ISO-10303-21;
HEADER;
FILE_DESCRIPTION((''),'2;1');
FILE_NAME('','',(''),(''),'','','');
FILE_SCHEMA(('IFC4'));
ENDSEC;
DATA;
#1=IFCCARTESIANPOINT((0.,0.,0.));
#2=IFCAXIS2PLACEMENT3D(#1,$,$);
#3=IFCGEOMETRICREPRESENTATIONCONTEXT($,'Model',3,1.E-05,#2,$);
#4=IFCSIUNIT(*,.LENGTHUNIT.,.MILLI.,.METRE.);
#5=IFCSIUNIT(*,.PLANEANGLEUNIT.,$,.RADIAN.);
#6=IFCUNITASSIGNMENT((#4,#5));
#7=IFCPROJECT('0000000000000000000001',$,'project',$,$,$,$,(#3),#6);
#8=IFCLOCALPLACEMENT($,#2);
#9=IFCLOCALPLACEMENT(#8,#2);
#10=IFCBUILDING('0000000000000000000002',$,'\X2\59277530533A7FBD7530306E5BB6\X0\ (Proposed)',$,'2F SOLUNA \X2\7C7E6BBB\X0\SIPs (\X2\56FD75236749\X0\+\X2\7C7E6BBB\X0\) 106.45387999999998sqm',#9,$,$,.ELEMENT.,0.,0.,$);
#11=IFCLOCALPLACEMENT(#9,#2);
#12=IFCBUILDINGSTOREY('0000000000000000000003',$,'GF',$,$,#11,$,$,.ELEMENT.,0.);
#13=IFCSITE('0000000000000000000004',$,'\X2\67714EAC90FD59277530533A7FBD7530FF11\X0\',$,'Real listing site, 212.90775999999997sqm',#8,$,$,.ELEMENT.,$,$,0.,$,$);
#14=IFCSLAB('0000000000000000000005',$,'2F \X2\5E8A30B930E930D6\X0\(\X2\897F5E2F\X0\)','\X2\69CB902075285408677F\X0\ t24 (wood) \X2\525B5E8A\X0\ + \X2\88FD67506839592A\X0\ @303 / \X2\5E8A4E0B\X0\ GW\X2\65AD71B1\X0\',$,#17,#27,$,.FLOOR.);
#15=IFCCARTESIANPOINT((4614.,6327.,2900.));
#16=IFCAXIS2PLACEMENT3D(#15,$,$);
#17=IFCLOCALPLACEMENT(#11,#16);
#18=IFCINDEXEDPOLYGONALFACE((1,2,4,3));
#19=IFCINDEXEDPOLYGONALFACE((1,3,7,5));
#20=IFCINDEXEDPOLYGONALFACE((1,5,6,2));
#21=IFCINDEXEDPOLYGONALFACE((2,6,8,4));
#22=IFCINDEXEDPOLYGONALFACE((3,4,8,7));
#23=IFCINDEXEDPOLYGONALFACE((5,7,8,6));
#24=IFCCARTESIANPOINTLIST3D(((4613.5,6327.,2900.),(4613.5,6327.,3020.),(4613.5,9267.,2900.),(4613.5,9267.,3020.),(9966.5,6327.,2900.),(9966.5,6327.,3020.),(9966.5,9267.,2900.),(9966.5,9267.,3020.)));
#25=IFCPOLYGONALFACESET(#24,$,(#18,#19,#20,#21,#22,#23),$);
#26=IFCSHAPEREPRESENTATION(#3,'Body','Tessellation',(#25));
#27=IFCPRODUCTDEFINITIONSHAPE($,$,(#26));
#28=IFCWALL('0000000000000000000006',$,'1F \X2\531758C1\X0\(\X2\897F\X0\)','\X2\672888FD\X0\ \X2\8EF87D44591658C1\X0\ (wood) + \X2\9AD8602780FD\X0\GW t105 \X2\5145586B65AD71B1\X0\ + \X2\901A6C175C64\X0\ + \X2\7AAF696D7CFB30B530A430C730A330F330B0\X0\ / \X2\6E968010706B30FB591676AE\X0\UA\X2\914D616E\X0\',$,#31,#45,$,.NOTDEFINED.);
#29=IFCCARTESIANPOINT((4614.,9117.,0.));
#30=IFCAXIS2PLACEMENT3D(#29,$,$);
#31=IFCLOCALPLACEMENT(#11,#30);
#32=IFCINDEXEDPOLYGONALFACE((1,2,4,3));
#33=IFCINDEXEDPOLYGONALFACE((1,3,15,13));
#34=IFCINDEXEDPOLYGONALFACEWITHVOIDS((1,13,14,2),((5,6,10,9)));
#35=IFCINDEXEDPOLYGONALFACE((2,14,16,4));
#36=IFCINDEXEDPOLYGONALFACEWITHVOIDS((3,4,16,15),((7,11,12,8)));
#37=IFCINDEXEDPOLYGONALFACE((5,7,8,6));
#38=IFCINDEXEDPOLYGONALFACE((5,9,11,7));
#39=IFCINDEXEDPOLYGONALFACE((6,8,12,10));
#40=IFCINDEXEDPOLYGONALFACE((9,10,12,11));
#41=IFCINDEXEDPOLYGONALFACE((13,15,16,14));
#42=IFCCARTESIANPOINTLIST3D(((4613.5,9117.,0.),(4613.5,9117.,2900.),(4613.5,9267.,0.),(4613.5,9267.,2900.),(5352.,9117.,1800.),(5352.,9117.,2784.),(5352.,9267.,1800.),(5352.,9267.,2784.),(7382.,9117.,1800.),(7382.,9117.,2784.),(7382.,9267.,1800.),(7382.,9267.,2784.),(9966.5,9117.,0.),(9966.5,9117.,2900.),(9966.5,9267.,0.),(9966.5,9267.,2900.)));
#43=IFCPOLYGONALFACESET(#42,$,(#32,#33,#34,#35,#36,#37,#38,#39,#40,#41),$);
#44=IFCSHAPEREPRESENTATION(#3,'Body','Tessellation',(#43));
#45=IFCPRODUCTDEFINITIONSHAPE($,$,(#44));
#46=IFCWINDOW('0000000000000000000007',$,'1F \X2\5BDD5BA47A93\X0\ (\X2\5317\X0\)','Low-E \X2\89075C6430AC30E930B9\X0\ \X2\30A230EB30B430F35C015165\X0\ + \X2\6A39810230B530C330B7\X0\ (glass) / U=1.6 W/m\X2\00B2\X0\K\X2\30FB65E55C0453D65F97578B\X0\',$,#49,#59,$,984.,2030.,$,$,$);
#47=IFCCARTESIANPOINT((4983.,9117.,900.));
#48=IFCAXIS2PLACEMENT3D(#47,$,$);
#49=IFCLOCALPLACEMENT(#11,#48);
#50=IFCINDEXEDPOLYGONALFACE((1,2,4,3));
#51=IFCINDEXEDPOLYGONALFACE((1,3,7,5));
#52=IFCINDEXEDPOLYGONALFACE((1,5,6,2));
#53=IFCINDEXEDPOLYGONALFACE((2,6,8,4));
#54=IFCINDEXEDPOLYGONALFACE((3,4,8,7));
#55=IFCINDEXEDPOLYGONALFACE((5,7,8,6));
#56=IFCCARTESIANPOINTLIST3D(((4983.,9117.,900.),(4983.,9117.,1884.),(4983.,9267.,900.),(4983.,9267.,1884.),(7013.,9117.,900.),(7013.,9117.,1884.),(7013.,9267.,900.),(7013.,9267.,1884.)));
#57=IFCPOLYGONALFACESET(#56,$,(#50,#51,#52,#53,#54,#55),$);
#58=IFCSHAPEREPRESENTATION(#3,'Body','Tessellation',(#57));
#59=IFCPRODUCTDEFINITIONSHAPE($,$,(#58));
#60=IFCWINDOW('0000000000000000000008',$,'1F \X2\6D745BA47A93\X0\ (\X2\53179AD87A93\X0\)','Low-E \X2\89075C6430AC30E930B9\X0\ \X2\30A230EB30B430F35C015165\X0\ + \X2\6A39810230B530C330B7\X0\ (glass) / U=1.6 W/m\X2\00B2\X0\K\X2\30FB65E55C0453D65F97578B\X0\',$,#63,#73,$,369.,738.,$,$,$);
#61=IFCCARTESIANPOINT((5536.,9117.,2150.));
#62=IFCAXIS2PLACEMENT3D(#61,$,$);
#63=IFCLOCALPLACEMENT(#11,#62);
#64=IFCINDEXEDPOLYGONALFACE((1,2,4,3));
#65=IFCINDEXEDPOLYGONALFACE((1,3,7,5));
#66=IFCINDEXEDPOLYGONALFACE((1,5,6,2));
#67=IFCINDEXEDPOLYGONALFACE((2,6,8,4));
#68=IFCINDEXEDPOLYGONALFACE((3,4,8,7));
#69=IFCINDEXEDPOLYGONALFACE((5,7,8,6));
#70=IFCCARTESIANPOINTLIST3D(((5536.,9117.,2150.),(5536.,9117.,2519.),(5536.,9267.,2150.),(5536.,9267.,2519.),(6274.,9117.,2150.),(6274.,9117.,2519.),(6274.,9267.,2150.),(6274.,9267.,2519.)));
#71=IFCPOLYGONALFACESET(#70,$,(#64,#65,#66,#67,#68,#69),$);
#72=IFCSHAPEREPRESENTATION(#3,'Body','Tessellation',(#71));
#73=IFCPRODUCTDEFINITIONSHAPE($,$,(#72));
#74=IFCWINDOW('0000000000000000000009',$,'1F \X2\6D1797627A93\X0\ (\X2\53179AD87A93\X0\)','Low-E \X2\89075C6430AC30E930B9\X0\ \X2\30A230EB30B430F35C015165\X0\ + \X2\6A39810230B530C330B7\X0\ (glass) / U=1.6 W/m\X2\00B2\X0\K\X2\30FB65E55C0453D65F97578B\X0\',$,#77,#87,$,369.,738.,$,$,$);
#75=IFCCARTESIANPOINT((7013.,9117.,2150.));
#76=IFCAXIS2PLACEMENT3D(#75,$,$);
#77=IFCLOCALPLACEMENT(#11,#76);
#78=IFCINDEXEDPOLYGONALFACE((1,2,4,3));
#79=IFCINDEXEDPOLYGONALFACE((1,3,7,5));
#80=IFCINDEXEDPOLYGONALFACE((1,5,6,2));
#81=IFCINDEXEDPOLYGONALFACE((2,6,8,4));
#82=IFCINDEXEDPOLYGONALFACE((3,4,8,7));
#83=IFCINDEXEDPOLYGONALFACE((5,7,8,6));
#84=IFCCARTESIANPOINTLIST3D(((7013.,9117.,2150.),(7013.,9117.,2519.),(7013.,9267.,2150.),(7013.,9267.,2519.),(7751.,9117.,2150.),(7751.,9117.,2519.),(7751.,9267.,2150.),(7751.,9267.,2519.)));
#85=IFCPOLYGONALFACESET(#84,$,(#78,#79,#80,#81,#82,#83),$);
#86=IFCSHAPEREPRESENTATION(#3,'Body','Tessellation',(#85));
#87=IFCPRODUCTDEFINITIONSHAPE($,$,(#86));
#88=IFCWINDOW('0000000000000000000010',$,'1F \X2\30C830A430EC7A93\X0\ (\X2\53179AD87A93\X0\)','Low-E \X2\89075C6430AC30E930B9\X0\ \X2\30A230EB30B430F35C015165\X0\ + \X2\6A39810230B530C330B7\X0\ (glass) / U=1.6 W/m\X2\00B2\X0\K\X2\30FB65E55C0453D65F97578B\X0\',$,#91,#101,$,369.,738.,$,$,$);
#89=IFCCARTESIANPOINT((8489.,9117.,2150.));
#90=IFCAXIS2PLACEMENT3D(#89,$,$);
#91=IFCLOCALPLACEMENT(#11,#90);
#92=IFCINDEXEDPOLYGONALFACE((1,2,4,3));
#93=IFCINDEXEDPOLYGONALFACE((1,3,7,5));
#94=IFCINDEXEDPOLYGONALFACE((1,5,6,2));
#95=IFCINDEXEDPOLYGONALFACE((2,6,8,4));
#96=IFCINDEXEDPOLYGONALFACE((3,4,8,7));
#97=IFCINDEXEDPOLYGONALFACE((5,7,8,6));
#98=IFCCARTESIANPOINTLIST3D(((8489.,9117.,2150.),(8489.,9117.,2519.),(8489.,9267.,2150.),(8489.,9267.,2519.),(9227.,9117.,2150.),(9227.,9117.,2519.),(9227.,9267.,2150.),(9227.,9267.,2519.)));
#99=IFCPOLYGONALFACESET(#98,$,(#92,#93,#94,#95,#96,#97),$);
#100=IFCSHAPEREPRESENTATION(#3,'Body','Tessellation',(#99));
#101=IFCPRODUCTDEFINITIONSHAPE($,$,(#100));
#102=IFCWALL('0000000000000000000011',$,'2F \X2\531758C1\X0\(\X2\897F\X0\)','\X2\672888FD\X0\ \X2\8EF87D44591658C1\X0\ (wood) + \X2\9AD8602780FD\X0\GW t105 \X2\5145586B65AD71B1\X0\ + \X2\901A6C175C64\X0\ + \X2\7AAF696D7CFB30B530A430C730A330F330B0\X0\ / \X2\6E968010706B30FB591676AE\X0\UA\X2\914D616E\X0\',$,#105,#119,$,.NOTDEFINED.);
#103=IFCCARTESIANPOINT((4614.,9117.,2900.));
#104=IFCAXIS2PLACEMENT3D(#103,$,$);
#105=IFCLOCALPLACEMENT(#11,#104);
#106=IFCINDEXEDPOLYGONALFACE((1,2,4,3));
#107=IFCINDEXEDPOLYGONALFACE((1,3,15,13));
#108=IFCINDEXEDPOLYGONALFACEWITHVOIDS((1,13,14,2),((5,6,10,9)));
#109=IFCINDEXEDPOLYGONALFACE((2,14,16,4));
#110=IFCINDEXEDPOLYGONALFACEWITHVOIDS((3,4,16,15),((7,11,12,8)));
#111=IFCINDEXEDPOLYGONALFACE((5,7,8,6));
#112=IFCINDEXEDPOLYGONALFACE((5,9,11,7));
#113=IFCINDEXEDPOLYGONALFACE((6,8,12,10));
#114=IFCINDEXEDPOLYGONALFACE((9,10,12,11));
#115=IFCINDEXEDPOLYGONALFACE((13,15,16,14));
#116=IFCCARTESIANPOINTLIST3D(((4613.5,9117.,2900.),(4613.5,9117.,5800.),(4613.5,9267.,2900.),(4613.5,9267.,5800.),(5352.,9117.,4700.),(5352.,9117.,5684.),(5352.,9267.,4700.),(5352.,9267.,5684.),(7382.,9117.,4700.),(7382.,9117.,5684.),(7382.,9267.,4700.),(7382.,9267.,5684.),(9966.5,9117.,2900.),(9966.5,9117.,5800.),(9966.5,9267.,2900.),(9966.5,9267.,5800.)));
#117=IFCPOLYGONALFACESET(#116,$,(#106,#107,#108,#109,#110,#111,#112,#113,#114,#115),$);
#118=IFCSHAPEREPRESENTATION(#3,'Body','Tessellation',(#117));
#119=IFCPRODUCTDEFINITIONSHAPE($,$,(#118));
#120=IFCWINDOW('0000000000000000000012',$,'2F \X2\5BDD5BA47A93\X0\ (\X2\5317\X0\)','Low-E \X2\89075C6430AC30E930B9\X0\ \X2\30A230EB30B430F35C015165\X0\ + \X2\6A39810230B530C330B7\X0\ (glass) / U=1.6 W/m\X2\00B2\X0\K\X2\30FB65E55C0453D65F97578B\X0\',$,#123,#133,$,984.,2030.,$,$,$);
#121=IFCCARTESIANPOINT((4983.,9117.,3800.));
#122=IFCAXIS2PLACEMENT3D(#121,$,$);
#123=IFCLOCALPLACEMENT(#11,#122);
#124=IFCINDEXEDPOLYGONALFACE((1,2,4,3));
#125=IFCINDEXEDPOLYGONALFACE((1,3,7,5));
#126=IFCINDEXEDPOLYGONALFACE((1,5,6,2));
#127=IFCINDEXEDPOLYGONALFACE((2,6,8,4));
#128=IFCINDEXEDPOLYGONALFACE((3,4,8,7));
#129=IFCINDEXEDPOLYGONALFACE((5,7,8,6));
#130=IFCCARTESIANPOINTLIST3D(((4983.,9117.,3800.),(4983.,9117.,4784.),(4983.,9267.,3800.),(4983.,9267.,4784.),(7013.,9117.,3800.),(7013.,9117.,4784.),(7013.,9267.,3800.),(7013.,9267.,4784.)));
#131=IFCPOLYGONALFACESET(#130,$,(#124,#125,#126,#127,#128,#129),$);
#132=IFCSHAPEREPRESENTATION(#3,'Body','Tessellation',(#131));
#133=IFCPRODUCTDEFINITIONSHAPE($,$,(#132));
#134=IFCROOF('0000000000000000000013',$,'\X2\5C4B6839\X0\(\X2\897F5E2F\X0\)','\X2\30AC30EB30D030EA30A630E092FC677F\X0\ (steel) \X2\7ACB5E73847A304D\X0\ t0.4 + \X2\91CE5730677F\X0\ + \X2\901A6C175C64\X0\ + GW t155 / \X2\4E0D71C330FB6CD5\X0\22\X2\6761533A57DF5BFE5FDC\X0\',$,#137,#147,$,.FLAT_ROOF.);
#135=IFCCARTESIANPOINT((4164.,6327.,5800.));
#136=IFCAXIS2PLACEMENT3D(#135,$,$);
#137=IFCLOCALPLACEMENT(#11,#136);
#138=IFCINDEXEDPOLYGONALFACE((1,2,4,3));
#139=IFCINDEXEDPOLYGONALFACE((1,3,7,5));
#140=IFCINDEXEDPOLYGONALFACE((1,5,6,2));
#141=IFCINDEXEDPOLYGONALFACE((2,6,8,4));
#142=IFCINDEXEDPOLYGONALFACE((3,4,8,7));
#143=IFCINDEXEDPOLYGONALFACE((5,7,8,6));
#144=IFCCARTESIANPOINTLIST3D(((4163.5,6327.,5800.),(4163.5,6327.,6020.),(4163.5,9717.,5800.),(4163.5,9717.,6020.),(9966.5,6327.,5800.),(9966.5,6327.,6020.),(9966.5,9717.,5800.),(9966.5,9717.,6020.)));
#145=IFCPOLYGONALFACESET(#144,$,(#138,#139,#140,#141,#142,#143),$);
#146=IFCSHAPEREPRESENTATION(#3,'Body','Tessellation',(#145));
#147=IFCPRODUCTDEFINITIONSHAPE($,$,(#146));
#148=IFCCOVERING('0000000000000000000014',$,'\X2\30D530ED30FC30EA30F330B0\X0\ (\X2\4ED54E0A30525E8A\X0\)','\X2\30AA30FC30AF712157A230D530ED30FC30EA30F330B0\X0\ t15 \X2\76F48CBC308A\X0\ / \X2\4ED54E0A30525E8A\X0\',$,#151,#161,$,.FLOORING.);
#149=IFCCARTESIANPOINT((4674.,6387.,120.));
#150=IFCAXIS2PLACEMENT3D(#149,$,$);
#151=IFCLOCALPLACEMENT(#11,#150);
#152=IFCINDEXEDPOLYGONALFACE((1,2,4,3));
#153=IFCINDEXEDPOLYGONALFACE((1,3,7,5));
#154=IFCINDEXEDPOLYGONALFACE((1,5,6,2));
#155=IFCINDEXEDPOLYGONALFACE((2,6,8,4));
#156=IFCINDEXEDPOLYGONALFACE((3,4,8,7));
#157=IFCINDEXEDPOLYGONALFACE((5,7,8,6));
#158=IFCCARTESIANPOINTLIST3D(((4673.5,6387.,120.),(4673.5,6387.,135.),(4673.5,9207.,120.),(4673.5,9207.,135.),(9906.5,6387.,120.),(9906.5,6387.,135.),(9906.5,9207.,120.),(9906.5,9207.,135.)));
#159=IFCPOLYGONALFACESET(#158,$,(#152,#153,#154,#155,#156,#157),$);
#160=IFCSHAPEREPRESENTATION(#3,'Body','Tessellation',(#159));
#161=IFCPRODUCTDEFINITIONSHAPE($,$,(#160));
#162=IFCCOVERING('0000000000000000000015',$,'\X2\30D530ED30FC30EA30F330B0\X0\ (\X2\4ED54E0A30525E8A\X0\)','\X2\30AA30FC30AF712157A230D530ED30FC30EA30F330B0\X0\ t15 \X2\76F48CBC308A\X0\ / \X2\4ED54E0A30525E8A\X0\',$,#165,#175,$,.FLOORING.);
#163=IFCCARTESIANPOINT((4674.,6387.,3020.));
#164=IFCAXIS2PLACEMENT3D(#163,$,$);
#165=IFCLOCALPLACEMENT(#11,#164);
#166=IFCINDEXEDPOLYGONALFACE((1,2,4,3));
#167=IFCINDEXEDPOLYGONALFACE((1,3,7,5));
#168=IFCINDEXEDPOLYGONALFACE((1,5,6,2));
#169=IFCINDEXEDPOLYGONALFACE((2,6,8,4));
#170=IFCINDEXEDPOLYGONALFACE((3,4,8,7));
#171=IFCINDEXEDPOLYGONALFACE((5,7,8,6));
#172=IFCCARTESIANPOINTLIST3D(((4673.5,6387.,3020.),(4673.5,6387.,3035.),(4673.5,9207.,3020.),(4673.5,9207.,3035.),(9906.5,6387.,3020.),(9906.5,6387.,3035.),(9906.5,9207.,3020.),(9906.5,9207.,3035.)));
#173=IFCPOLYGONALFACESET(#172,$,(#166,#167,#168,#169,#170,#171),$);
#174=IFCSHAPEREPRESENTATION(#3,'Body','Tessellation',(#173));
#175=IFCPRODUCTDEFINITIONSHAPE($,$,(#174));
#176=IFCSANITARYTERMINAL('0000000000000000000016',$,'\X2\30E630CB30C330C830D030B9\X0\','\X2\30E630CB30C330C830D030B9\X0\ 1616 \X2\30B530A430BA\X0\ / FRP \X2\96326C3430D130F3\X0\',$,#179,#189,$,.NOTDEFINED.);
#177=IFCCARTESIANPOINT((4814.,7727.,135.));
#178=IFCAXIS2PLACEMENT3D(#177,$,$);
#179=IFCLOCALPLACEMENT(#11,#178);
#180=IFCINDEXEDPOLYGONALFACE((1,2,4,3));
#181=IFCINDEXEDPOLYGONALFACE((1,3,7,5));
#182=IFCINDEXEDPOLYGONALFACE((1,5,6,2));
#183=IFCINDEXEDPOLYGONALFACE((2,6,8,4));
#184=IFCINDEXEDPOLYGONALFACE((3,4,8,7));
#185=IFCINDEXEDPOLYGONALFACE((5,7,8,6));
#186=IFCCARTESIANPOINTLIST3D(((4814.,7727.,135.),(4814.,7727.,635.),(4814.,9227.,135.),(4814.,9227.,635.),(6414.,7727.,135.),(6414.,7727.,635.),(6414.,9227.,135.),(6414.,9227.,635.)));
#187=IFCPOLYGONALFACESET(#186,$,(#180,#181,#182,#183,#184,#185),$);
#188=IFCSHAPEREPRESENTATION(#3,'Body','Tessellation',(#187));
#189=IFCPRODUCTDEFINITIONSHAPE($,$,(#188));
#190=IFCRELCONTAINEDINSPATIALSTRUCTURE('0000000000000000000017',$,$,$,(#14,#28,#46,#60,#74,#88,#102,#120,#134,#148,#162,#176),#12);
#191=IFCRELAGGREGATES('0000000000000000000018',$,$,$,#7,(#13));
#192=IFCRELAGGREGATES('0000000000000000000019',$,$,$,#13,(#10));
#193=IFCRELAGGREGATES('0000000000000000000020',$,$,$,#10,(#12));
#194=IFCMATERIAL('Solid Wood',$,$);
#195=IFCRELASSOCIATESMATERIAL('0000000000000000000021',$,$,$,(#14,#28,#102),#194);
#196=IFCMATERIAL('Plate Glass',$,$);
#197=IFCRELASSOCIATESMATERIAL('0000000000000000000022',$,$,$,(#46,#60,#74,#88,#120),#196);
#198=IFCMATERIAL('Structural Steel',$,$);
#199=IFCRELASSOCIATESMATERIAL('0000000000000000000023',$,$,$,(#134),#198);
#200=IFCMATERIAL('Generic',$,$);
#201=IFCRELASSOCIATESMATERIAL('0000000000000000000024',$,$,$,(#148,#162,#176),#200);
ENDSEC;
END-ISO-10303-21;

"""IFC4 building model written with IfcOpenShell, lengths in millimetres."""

from ifc_helpers import new_model, si_unit, frame, frame_2d, origin, place, context, project, spatial, rectangle, extrude, material, element, fill, save


model = new_model("IFC4")

# Units and contexts
model_context = context("Model", 3, precision=1e-05, world=origin())
ifc_project = project(units=[si_unit("LENGTHUNIT", "METRE", prefix="MILLI"), si_unit("PLANEANGLEUNIT", "RADIAN")], contexts=[model_context])

# Site, building, storey
site_placement = place(None, origin())
site = spatial("IfcSite", under=ifc_project, at=site_placement, Name="東京都大田区羽田１", ObjectType="Real listing site, 212.90775999999997sqm", CompositionType="ELEMENT", RefElevation=0.0)
building_placement = place(site_placement, origin())
building = spatial("IfcBuilding", under=site, at=building_placement, Name="大田区羽田の家 (Proposed)", ObjectType="2F SOLUNA 籾殻SIPs (国産杉+籾殻) 106.45387999999998sqm", CompositionType="ELEMENT", ElevationOfRefHeight=0.0, ElevationOfTerrain=0.0)
storey_placement = place(building_placement, origin())
storey = spatial("IfcBuildingStorey", under=building, at=storey_placement, Name="GF", CompositionType="ELEMENT", Elevation=0.0)

# Slab
ifc_material_1 = material(Name="Solid Wood")
slab_1_placement = place(storey_placement, frame((4614.0, 6327.0, 2900.0)))
element("IfcSlab", 1, at=slab_1_placement, inside=storey, material=ifc_material_1, Name="2F 床スラブ(西帯)", Description="構造用合板 t24 (wood) 剛床 + 製材根太 @303 / 床下 GW断熱", PredefinedType="FLOOR", context=model_context, shape_type="SweptSolid", body=[
    extrude(rectangle(XDim=5353.0, YDim=2940.0, at=frame_2d((2676.0, 1470.0))), frame((4614.0, 6327.0, 2900.0)), (0.0, 0.0, 1.0), 120.0),
])

# Wall, openings, windows
wall_1_placement = place(storey_placement, frame((4614.0, 9117.0, 0.0)))
wall_1 = element("IfcWall", 2, at=wall_1_placement, inside=storey, material=ifc_material_1, Name="1F 北壁(西)", Description="木製 軸組外壁 (wood) + 高性能GW t105 充填断熱 + 通気層 + 窯業系サイディング / 準耐火・外皮UA配慮", PredefinedType="NOTDEFINED", context=model_context, shape_type="SweptSolid", body=[
    extrude(rectangle(XDim=5353.0, YDim=150.0, at=frame_2d((2676.0, 75.0))), frame((4614.0, 9117.0, 0.0)), (0.0, 0.0, 1.0), 2900.0),
])
opening_1_placement = place(storey_placement, frame((4983.0, 9117.0, 900.0)))
opening_1 = element("IfcOpeningElement", 3, at=opening_1_placement, cuts=wall_1, PredefinedType="NOTDEFINED", context=model_context, shape_type="SweptSolid", body=[
    extrude(rectangle(XDim=2030.0, YDim=150.0, at=frame_2d((1015.0, 75.0))), frame((4983.0, 9117.0, 900.0)), (0.0, 0.0, 1.0), 984.0),
])
opening_2_placement = place(storey_placement, frame((5536.0, 9117.0, 2150.0)))
opening_2 = element("IfcOpeningElement", 4, at=opening_2_placement, cuts=wall_1, PredefinedType="NOTDEFINED", context=model_context, shape_type="SweptSolid", body=[
    extrude(rectangle(XDim=738.0, YDim=150.0, at=frame_2d((369.0, 75.0))), frame((5536.0, 9117.0, 2150.0)), (0.0, 0.0, 1.0), 369.0),
])
opening_3_placement = place(storey_placement, frame((7013.0, 9117.0, 2150.0)))
opening_3 = element("IfcOpeningElement", 5, at=opening_3_placement, cuts=wall_1, PredefinedType="NOTDEFINED", context=model_context, shape_type="SweptSolid", body=[
    extrude(rectangle(XDim=738.0, YDim=150.0, at=frame_2d((369.0, 75.0))), frame((7013.0, 9117.0, 2150.0)), (0.0, 0.0, 1.0), 369.0),
])
opening_4_placement = place(storey_placement, frame((8489.0, 9117.0, 2150.0)))
opening_4 = element("IfcOpeningElement", 6, at=opening_4_placement, cuts=wall_1, PredefinedType="NOTDEFINED", context=model_context, shape_type="SweptSolid", body=[
    extrude(rectangle(XDim=738.0, YDim=150.0, at=frame_2d((369.0, 75.0))), frame((8489.0, 9117.0, 2150.0)), (0.0, 0.0, 1.0), 369.0),
])
ifc_material_2 = material(Name="Plate Glass")
window_1_placement = place(storey_placement, frame((4983.0, 9117.0, 900.0)))
window_1 = element("IfcWindow", 7, at=window_1_placement, inside=storey, material=ifc_material_2, Name="1F 寝室窓 (北)", Description="Low-E 複層ガラス アルゴン封入 + 樹脂サッシ (glass) / U=1.6 W/m²K・日射取得型", OverallHeight=984.0, OverallWidth=2030.0, context=model_context, shape_type="SweptSolid", body=[
    extrude(rectangle(XDim=2030.0, YDim=150.0, at=frame_2d((1015.0, 75.0))), frame((4983.0, 9117.0, 900.0)), (0.0, 0.0, 1.0), 984.0),
])
fill(opening_1, window_1)
window_2_placement = place(storey_placement, frame((5536.0, 9117.0, 2150.0)))
window_2 = element("IfcWindow", 8, at=window_2_placement, inside=storey, material=ifc_material_2, Name="1F 浴室窓 (北高窓)", Description="Low-E 複層ガラス アルゴン封入 + 樹脂サッシ (glass) / U=1.6 W/m²K・日射取得型", OverallHeight=369.0, OverallWidth=738.0, context=model_context, shape_type="SweptSolid", body=[
    extrude(rectangle(XDim=738.0, YDim=150.0, at=frame_2d((369.0, 75.0))), frame((5536.0, 9117.0, 2150.0)), (0.0, 0.0, 1.0), 369.0),
])
fill(opening_2, window_2)
window_3_placement = place(storey_placement, frame((7013.0, 9117.0, 2150.0)))
window_3 = element("IfcWindow", 9, at=window_3_placement, inside=storey, material=ifc_material_2, Name="1F 洗面窓 (北高窓)", Description="Low-E 複層ガラス アルゴン封入 + 樹脂サッシ (glass) / U=1.6 W/m²K・日射取得型", OverallHeight=369.0, OverallWidth=738.0, context=model_context, shape_type="SweptSolid", body=[
    extrude(rectangle(XDim=738.0, YDim=150.0, at=frame_2d((369.0, 75.0))), frame((7013.0, 9117.0, 2150.0)), (0.0, 0.0, 1.0), 369.0),
])
fill(opening_3, window_3)
window_4_placement = place(storey_placement, frame((8489.0, 9117.0, 2150.0)))
window_4 = element("IfcWindow", 10, at=window_4_placement, inside=storey, material=ifc_material_2, Name="1F トイレ窓 (北高窓)", Description="Low-E 複層ガラス アルゴン封入 + 樹脂サッシ (glass) / U=1.6 W/m²K・日射取得型", OverallHeight=369.0, OverallWidth=738.0, context=model_context, shape_type="SweptSolid", body=[
    extrude(rectangle(XDim=738.0, YDim=150.0, at=frame_2d((369.0, 75.0))), frame((8489.0, 9117.0, 2150.0)), (0.0, 0.0, 1.0), 369.0),
])
fill(opening_4, window_4)

# Wall, opening, window
wall_2_placement = place(storey_placement, frame((4614.0, 9117.0, 2900.0)))
wall_2 = element("IfcWall", 11, at=wall_2_placement, inside=storey, material=ifc_material_1, Name="2F 北壁(西)", Description="木製 軸組外壁 (wood) + 高性能GW t105 充填断熱 + 通気層 + 窯業系サイディング / 準耐火・外皮UA配慮", PredefinedType="NOTDEFINED", context=model_context, shape_type="SweptSolid", body=[
    extrude(rectangle(XDim=5353.0, YDim=150.0, at=frame_2d((2676.0, 75.0))), frame((4614.0, 9117.0, 2900.0)), (0.0, 0.0, 1.0), 2900.0),
])
opening_5_placement = place(storey_placement, frame((4983.0, 9117.0, 3800.0)))
opening_5 = element("IfcOpeningElement", 12, at=opening_5_placement, cuts=wall_2, PredefinedType="NOTDEFINED", context=model_context, shape_type="SweptSolid", body=[
    extrude(rectangle(XDim=2030.0, YDim=150.0, at=frame_2d((1015.0, 75.0))), frame((4983.0, 9117.0, 3800.0)), (0.0, 0.0, 1.0), 984.0),
])
window_5_placement = place(storey_placement, frame((4983.0, 9117.0, 3800.0)))
window_5 = element("IfcWindow", 13, at=window_5_placement, inside=storey, material=ifc_material_2, Name="2F 寝室窓 (北)", Description="Low-E 複層ガラス アルゴン封入 + 樹脂サッシ (glass) / U=1.6 W/m²K・日射取得型", OverallHeight=984.0, OverallWidth=2030.0, context=model_context, shape_type="SweptSolid", body=[
    extrude(rectangle(XDim=2030.0, YDim=150.0, at=frame_2d((1015.0, 75.0))), frame((4983.0, 9117.0, 3800.0)), (0.0, 0.0, 1.0), 984.0),
])
fill(opening_5, window_5)

# Roof
ifc_material_3 = material(Name="Structural Steel")
for number, where, name in (
    (14, (4164.0, 6327.0, 5800.0), "屋根(西帯)"),
):
    element("IfcRoof", number, at=place(storey_placement, frame(where)), inside=storey, material=ifc_material_3, Name=name, Description="ガルバリウム鋼板 (steel) 立平葺き t0.4 + 野地板 + 通気層 + GW t155 / 不燃・法22条区域対応", PredefinedType="FLAT_ROOF", context=model_context, shape_type="SweptSolid", body=[
        extrude(rectangle(XDim=5803.0, YDim=3390.0, at=frame_2d((2901.0, 1695.0))), frame((4164.0, 6327.0, 5800.0)), (0.0, 0.0, 1.0), 220.0),
    ])

# Coverings
ifc_material_4 = material(Name="Generic")
covering_1_placement = place(storey_placement, frame((4674.0, 6387.0, 120.0)))
element("IfcCovering", 15, at=covering_1_placement, inside=storey, material=ifc_material_4, Name="フローリング (仕上げ床)", Description="オーク無垢フローリング t15 直貼り / 仕上げ床", PredefinedType="FLOORING", context=model_context, shape_type="SweptSolid", body=[
    extrude(rectangle(XDim=5233.0, YDim=2820.0, at=frame_2d((2616.0, 1410.0))), frame((4674.0, 6387.0, 120.0)), (0.0, 0.0, 1.0), 15.0),
])
covering_2_placement = place(storey_placement, frame((4674.0, 6387.0, 3020.0)))
element("IfcCovering", 16, at=covering_2_placement, inside=storey, material=ifc_material_4, Name="フローリング (仕上げ床)", Description="オーク無垢フローリング t15 直貼り / 仕上げ床", PredefinedType="FLOORING", context=model_context, shape_type="SweptSolid", body=[
    extrude(rectangle(XDim=5233.0, YDim=2820.0, at=frame_2d((2616.0, 1410.0))), frame((4674.0, 6387.0, 3020.0)), (0.0, 0.0, 1.0), 15.0),
])

# Sanitary terminal
sanitary_terminal_placement = place(storey_placement, frame((4814.0, 7727.0, 135.0)))
element("IfcSanitaryTerminal", 17, at=sanitary_terminal_placement, inside=storey, material=ifc_material_4, Name="ユニットバス", Description="ユニットバス 1616 サイズ / FRP 防水パン", PredefinedType="NOTDEFINED", context=model_context, shape_type="SweptSolid", body=[
    extrude(rectangle(XDim=1600.0, YDim=1500.0, at=frame_2d((800.0, 750.0))), frame((4814.0, 7727.0, 135.0)), (0.0, 0.0, 1.0), 500.0),
])

save(model, "model.ifc")
